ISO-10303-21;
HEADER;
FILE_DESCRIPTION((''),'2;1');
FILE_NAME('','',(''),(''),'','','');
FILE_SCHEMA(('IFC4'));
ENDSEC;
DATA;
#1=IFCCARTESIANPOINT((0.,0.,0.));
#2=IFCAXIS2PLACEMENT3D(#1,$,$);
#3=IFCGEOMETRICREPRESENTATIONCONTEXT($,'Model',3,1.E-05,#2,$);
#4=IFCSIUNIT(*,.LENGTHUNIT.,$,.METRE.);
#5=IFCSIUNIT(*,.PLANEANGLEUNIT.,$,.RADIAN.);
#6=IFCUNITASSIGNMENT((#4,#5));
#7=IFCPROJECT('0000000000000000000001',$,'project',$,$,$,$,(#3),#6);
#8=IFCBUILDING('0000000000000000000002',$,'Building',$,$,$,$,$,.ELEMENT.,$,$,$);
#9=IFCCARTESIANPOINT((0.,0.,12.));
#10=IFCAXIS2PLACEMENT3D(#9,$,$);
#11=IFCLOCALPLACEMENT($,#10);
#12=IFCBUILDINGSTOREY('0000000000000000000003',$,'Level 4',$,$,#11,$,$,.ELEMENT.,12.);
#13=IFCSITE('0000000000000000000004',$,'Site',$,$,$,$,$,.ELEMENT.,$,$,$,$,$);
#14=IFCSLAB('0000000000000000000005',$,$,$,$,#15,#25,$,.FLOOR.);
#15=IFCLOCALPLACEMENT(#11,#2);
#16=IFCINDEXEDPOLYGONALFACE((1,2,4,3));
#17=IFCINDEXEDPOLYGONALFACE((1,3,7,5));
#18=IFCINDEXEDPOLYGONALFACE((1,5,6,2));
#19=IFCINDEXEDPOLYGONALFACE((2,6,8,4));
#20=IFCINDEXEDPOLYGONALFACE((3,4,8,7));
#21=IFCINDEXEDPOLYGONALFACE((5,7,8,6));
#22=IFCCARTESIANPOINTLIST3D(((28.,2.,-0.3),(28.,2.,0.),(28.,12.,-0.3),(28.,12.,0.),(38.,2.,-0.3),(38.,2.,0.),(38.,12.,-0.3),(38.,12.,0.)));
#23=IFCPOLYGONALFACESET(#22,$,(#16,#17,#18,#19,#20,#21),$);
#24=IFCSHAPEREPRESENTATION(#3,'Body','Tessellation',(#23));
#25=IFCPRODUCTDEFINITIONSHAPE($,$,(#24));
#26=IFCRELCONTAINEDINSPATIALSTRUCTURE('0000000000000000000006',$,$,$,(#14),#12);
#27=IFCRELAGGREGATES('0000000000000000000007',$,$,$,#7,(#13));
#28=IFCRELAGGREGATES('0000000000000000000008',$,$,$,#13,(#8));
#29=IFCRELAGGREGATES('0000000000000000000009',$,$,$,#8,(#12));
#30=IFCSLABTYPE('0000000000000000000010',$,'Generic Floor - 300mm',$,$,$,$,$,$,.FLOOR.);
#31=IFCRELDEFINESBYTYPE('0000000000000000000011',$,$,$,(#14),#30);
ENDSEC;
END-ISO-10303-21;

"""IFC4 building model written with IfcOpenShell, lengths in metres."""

from ifc_helpers import new_model, si_unit, frame, origin, place, context, project, spatial, polyline, outline, extrude, type_object, element, save


model = new_model("IFC4")

# Units and contexts
model_context = context("Model", 3, precision=1e-05, world=origin())
ifc_project = project(units=[si_unit("LENGTHUNIT", "METRE"), si_unit("PLANEANGLEUNIT", "RADIAN")], contexts=[model_context])

# Site, building, storey
site = spatial("IfcSite", under=ifc_project, Name="Site", CompositionType="ELEMENT")
building = spatial("IfcBuilding", under=site, Name="Building", CompositionType="ELEMENT")
storey_placement = place(None, frame((0.0, 0.0, 12.0)))
storey = spatial("IfcBuildingStorey", under=building, at=storey_placement, Name="Level 4", CompositionType="ELEMENT", Elevation=12.0)

# Slab
slab_type = type_object("IfcSlabType", Name="Generic Floor - 300mm", PredefinedType="FLOOR")
slab_placement = place(None, frame((0.0, 0.0, 12.0)))
element("IfcSlab", 1, at=slab_placement, inside=storey, type_object=slab_type, PredefinedType="FLOOR", context=model_context, shape_type="SweptSolid", body=[
    extrude(outline(polyline([(28.0, 12.0), (28.0, 2.0), (38.0, 2.0), (38.0, 12.0), (28.0, 12.0)])), origin(), (0.0, 0.0, -1.0), 0.3),
])

save(model, "model.ifc")
